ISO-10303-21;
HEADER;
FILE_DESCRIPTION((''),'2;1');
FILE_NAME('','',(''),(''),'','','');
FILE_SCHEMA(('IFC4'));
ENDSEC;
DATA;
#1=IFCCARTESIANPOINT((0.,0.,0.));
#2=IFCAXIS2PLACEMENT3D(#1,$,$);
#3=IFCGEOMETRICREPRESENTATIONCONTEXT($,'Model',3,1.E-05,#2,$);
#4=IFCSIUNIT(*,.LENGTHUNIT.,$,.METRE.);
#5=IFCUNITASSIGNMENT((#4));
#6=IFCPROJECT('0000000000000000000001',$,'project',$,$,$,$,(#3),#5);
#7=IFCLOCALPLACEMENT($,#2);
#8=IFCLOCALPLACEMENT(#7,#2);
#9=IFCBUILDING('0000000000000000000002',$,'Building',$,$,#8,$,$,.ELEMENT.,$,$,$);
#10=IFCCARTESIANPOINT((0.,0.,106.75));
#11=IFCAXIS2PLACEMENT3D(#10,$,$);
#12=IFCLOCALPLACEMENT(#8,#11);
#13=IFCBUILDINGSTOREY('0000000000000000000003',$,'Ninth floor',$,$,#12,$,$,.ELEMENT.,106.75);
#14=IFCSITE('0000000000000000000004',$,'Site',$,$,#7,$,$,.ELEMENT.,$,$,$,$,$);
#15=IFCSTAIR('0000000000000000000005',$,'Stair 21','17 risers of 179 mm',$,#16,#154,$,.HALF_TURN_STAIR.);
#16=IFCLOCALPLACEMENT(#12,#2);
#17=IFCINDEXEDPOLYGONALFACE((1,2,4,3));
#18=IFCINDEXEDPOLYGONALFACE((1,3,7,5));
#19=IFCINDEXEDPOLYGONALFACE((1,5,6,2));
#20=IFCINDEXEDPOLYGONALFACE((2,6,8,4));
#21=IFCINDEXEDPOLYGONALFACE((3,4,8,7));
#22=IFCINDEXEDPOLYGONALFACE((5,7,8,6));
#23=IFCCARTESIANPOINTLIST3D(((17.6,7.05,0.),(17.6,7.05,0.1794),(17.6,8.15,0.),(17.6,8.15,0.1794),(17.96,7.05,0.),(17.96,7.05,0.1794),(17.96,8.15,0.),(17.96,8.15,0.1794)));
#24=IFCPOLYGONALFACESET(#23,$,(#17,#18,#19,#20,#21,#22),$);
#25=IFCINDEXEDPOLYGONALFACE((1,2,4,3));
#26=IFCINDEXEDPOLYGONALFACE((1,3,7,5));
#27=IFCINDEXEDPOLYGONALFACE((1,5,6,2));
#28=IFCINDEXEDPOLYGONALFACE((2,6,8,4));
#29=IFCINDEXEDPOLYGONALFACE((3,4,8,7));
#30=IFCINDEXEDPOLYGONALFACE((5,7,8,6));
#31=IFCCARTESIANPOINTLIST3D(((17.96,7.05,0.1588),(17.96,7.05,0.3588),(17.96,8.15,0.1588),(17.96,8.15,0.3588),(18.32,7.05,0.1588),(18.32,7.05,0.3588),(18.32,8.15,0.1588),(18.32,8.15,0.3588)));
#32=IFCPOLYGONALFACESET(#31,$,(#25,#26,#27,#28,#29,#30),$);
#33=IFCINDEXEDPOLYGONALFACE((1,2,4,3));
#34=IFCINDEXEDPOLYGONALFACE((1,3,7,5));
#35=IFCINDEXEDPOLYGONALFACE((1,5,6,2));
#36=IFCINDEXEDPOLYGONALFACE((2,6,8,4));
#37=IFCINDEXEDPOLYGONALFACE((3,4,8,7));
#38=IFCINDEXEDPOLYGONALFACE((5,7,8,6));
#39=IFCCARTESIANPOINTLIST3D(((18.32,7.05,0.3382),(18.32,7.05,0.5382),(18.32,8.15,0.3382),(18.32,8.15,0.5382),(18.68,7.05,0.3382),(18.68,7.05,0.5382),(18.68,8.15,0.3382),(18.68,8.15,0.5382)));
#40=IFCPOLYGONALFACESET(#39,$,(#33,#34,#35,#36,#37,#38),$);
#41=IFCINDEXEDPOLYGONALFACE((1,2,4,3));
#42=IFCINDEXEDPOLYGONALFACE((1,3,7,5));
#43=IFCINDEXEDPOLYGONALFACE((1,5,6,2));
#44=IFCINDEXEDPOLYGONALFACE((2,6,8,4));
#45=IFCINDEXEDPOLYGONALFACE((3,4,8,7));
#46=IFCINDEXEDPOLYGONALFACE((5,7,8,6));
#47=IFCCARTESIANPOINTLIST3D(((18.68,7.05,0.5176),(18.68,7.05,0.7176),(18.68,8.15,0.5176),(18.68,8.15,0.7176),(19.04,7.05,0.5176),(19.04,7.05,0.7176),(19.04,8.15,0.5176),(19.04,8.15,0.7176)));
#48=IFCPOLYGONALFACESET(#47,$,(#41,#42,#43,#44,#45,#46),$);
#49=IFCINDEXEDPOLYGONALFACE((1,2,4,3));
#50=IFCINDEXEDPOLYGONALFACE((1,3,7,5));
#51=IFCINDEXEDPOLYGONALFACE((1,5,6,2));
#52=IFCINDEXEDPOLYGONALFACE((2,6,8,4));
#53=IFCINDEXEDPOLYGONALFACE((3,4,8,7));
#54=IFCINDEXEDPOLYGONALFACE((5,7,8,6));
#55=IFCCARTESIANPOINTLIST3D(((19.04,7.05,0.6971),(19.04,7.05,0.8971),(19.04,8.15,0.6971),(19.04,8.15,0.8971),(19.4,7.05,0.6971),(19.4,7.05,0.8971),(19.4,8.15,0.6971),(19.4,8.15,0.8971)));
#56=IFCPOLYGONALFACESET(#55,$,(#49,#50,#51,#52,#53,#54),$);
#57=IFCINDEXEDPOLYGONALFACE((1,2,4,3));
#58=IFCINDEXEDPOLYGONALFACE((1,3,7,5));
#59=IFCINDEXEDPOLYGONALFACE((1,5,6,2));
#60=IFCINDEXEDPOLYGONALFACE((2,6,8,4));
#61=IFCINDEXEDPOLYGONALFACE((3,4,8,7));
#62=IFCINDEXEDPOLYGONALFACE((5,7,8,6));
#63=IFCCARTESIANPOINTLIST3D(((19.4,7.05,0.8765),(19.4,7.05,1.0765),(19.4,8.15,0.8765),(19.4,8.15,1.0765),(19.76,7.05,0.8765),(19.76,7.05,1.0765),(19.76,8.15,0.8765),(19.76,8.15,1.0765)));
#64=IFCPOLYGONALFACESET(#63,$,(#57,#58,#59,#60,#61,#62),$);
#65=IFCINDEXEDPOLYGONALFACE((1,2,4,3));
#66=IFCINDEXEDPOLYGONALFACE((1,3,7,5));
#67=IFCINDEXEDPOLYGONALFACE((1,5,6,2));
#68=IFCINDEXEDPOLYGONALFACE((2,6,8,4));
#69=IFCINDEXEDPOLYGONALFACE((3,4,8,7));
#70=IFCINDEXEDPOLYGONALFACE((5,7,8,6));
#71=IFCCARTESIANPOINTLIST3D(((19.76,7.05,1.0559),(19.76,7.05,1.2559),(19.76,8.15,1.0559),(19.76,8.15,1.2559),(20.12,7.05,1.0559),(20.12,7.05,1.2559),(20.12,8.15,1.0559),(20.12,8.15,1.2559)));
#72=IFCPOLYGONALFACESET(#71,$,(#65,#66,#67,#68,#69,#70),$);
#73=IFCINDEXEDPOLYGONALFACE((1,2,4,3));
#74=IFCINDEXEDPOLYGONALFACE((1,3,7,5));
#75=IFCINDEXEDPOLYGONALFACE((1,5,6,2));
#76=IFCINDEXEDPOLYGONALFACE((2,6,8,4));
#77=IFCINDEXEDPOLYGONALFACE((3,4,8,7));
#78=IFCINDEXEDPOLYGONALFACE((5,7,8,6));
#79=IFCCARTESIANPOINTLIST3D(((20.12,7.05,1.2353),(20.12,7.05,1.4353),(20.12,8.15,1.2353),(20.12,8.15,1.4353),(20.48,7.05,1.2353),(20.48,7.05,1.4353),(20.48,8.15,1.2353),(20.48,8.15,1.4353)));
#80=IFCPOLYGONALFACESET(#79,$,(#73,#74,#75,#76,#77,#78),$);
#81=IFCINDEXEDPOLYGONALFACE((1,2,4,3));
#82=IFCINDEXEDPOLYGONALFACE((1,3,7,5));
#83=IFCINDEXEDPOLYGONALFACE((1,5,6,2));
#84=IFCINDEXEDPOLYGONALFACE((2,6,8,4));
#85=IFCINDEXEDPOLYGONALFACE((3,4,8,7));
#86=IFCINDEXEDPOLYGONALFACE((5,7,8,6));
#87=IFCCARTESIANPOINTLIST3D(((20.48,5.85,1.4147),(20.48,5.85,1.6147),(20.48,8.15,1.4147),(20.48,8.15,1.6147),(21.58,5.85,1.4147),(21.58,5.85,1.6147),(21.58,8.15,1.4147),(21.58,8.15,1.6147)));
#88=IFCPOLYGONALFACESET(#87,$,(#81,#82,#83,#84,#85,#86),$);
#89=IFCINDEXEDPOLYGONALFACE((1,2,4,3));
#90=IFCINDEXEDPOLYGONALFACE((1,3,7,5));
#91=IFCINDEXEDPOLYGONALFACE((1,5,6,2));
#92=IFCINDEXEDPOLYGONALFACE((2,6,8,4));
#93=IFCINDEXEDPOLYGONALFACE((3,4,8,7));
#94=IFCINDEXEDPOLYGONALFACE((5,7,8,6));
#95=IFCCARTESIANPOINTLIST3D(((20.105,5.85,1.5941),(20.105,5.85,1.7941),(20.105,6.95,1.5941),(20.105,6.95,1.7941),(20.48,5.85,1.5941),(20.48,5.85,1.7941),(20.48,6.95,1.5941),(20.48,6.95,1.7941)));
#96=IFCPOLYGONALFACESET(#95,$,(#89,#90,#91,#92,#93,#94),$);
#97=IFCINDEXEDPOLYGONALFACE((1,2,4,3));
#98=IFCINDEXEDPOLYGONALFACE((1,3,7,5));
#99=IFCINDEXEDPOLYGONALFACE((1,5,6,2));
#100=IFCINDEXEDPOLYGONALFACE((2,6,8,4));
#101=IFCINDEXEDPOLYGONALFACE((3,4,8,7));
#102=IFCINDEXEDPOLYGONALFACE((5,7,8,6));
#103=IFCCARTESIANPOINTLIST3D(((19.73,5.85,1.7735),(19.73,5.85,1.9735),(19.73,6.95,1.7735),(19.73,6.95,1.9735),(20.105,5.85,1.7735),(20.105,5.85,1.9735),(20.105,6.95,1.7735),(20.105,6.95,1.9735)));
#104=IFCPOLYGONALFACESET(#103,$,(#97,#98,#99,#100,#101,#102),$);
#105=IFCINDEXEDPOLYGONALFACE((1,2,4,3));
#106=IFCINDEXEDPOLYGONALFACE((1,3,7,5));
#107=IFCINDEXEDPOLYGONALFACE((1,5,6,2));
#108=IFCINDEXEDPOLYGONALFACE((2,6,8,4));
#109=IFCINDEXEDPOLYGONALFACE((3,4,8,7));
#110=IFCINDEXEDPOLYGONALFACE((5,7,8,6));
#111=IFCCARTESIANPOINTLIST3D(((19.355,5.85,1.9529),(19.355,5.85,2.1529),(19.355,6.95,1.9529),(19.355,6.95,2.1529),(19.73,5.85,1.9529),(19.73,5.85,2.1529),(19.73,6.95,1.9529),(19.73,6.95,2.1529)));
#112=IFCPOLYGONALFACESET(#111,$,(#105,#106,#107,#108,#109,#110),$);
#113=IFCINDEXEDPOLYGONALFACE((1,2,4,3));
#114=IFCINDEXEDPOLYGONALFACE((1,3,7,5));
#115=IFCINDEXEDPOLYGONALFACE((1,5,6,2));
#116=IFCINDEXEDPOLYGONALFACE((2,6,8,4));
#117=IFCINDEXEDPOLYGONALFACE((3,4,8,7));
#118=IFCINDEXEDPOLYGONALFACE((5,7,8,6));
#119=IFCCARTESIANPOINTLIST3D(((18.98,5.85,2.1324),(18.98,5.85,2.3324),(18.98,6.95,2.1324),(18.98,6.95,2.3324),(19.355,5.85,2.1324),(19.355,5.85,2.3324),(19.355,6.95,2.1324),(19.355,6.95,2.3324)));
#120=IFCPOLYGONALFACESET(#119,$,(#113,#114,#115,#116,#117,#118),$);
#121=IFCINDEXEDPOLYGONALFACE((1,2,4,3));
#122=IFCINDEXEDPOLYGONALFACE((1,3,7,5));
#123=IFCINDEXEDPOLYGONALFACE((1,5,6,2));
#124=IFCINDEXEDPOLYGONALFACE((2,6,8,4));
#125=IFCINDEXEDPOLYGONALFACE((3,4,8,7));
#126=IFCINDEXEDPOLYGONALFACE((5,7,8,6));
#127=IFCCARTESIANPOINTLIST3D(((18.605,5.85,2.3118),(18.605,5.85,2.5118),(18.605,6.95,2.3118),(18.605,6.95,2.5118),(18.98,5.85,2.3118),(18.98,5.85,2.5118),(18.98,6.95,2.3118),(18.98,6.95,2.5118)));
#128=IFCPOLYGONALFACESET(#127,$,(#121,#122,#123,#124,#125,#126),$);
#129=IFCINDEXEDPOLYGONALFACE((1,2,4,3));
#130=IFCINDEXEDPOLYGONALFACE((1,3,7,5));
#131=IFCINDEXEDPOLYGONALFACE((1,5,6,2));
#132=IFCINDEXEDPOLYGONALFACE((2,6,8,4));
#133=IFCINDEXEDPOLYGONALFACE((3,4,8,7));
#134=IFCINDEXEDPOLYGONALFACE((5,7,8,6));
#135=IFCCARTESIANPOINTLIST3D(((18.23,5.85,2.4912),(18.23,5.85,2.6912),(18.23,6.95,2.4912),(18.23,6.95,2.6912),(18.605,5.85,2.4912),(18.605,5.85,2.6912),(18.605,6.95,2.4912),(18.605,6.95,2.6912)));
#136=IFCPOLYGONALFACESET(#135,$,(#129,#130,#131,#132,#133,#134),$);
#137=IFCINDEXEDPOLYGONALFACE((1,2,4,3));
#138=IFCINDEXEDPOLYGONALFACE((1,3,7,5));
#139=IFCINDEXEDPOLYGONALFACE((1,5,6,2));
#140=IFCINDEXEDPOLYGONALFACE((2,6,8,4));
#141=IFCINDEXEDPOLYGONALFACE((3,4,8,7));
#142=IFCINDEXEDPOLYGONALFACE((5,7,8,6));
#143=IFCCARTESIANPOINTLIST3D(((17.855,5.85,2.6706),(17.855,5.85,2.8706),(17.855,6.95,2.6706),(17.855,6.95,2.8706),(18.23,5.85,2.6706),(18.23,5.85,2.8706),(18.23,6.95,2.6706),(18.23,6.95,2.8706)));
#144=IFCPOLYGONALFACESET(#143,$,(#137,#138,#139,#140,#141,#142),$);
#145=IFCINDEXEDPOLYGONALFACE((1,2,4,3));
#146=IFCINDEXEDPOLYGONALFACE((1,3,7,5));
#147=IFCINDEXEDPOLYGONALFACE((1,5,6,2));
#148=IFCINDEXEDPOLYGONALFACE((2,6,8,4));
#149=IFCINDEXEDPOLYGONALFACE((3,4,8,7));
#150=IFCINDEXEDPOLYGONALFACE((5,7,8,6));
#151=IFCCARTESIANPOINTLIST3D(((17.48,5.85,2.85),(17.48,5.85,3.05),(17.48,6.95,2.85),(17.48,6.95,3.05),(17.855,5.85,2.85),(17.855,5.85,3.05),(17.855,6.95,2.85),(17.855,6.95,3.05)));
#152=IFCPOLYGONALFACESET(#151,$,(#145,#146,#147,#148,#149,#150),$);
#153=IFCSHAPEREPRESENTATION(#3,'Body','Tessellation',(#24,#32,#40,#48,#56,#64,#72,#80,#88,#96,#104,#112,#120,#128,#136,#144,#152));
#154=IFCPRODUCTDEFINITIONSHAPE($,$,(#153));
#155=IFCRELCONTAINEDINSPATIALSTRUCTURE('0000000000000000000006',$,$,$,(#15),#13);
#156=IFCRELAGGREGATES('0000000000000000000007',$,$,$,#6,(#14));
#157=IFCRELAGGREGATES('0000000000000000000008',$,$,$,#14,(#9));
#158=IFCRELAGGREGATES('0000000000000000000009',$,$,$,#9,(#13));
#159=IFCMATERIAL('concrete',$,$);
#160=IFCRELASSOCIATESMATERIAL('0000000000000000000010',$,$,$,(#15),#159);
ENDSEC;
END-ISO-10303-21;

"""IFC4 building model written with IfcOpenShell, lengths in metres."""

from ifc_helpers import new_model, si_unit, frame, origin, place, context, project, spatial, polyline, outline, extrude, material, element, save


model = new_model("IFC4")

# Units and contexts
model_context = context("Model", 3, precision=1e-05, world=origin())
ifc_project = project(units=[si_unit("LENGTHUNIT", "METRE")], contexts=[model_context])

# Site, building, storey
site_placement = place(None, origin())
site = spatial("IfcSite", under=ifc_project, at=site_placement, Name="Site", CompositionType="ELEMENT")
building_placement = place(site_placement, origin())
building = spatial("IfcBuilding", under=site, at=building_placement, Name="Building", CompositionType="ELEMENT")
storey_placement = place(building_placement, frame((0.0, 0.0, 106.75)))
storey = spatial("IfcBuildingStorey", under=building, at=storey_placement, Name="Ninth floor", CompositionType="ELEMENT", Elevation=106.75)

# Shared definitions
ifc_material = material(Name="concrete")

# Stair
stair_1_placement = place(storey_placement, frame((17.6, 7.6, 0.0), z_axis=(0.0, 0.0, 1.0), x_axis=(1.0, 0.0, 0.0)))
element("IfcStair", 1, at=stair_1_placement, inside=storey, material=ifc_material, Name="Stair 21", Description="17 risers of 179 mm", PredefinedType="HALF_TURN_STAIR", context=model_context, shape_type="SweptSolid", body=[
    extrude(outline(polyline([(0.0, -0.55), (0.36, -0.55), (0.36, 0.55), (0.0, 0.55), (0.0, -0.55)])), origin(), (0.0, 0.0, 1.0), 0.1794),
    extrude(outline(polyline([(0.36, -0.55), (0.72, -0.55), (0.72, 0.55), (0.36, 0.55), (0.36, -0.55)])), frame((0.0, 0.0, 0.1588)), (0.0, 0.0, 1.0), 0.2),
    extrude(outline(polyline([(0.72, -0.55), (1.08, -0.55), (1.08, 0.55), (0.72, 0.55), (0.72, -0.55)])), frame((0.0, 0.0, 0.3382)), (0.0, 0.0, 1.0), 0.2),
    extrude(outline(polyline([(1.08, -0.55), (1.44, -0.55), (1.44, 0.55), (1.08, 0.55), (1.08, -0.55)])), frame((0.0, 0.0, 0.5176)), (0.0, 0.0, 1.0), 0.2),
    extrude(outline(polyline([(1.44, -0.55), (1.8, -0.55), (1.8, 0.55), (1.44, 0.55), (1.44, -0.55)])), frame((0.0, 0.0, 0.6971)), (0.0, 0.0, 1.0), 0.2),
    extrude(outline(polyline([(1.8, -0.55), (2.16, -0.55), (2.16, 0.55), (1.8, 0.55), (1.8, -0.55)])), frame((0.0, 0.0, 0.8765)), (0.0, 0.0, 1.0), 0.2),
    extrude(outline(polyline([(2.16, -0.55), (2.52, -0.55), (2.52, 0.55), (2.16, 0.55), (2.16, -0.55)])), frame((0.0, 0.0, 1.0559)), (0.0, 0.0, 1.0), 0.2),
    extrude(outline(polyline([(2.52, -0.55), (2.88, -0.55), (2.88, 0.55), (2.52, 0.55), (2.52, -0.55)])), frame((0.0, 0.0, 1.2353)), (0.0, 0.0, 1.0), 0.2),
    extrude(outline(polyline([(2.88, -1.75), (3.98, -1.75), (3.98, 0.55), (2.88, 0.55), (2.88, -1.75)])), frame((0.0, 0.0, 1.4147)), (0.0, 0.0, 1.0), 0.2),
    extrude(outline(polyline([(2.505, -1.75), (2.88, -1.75), (2.88, -0.65), (2.505, -0.65), (2.505, -1.75)])), frame((0.0, 0.0, 1.5941)), (0.0, 0.0, 1.0), 0.2),
    extrude(outline(polyline([(2.13, -1.75), (2.505, -1.75), (2.505, -0.65), (2.13, -0.65), (2.13, -1.75)])), frame((0.0, 0.0, 1.7735)), (0.0, 0.0, 1.0), 0.2),
    extrude(outline(polyline([(1.755, -1.75), (2.13, -1.75), (2.13, -0.65), (1.755, -0.65), (1.755, -1.75)])), frame((0.0, 0.0, 1.9529)), (0.0, 0.0, 1.0), 0.2),
    extrude(outline(polyline([(1.38, -1.75), (1.755, -1.75), (1.755, -0.65), (1.38, -0.65), (1.38, -1.75)])), frame((0.0, 0.0, 2.1324)), (0.0, 0.0, 1.0), 0.2),
    extrude(outline(polyline([(1.005, -1.75), (1.38, -1.75), (1.38, -0.65), (1.005, -0.65), (1.005, -1.75)])), frame((0.0, 0.0, 2.3118)), (0.0, 0.0, 1.0), 0.2),
    extrude(outline(polyline([(0.63, -1.75), (1.005, -1.75), (1.005, -0.65), (0.63, -0.65), (0.63, -1.75)])), frame((0.0, 0.0, 2.4912)), (0.0, 0.0, 1.0), 0.2),
    extrude(outline(polyline([(0.255, -1.75), (0.63, -1.75), (0.63, -0.65), (0.255, -0.65), (0.255, -1.75)])), frame((0.0, 0.0, 2.6706)), (0.0, 0.0, 1.0), 0.2),
    extrude(outline(polyline([(-0.12, -1.75), (0.255, -1.75), (0.255, -0.65), (-0.12, -0.65), (-0.12, -1.75)])), frame((0.0, 0.0, 2.85)), (0.0, 0.0, 1.0), 0.2),
])

save(model, "model.ifc")
